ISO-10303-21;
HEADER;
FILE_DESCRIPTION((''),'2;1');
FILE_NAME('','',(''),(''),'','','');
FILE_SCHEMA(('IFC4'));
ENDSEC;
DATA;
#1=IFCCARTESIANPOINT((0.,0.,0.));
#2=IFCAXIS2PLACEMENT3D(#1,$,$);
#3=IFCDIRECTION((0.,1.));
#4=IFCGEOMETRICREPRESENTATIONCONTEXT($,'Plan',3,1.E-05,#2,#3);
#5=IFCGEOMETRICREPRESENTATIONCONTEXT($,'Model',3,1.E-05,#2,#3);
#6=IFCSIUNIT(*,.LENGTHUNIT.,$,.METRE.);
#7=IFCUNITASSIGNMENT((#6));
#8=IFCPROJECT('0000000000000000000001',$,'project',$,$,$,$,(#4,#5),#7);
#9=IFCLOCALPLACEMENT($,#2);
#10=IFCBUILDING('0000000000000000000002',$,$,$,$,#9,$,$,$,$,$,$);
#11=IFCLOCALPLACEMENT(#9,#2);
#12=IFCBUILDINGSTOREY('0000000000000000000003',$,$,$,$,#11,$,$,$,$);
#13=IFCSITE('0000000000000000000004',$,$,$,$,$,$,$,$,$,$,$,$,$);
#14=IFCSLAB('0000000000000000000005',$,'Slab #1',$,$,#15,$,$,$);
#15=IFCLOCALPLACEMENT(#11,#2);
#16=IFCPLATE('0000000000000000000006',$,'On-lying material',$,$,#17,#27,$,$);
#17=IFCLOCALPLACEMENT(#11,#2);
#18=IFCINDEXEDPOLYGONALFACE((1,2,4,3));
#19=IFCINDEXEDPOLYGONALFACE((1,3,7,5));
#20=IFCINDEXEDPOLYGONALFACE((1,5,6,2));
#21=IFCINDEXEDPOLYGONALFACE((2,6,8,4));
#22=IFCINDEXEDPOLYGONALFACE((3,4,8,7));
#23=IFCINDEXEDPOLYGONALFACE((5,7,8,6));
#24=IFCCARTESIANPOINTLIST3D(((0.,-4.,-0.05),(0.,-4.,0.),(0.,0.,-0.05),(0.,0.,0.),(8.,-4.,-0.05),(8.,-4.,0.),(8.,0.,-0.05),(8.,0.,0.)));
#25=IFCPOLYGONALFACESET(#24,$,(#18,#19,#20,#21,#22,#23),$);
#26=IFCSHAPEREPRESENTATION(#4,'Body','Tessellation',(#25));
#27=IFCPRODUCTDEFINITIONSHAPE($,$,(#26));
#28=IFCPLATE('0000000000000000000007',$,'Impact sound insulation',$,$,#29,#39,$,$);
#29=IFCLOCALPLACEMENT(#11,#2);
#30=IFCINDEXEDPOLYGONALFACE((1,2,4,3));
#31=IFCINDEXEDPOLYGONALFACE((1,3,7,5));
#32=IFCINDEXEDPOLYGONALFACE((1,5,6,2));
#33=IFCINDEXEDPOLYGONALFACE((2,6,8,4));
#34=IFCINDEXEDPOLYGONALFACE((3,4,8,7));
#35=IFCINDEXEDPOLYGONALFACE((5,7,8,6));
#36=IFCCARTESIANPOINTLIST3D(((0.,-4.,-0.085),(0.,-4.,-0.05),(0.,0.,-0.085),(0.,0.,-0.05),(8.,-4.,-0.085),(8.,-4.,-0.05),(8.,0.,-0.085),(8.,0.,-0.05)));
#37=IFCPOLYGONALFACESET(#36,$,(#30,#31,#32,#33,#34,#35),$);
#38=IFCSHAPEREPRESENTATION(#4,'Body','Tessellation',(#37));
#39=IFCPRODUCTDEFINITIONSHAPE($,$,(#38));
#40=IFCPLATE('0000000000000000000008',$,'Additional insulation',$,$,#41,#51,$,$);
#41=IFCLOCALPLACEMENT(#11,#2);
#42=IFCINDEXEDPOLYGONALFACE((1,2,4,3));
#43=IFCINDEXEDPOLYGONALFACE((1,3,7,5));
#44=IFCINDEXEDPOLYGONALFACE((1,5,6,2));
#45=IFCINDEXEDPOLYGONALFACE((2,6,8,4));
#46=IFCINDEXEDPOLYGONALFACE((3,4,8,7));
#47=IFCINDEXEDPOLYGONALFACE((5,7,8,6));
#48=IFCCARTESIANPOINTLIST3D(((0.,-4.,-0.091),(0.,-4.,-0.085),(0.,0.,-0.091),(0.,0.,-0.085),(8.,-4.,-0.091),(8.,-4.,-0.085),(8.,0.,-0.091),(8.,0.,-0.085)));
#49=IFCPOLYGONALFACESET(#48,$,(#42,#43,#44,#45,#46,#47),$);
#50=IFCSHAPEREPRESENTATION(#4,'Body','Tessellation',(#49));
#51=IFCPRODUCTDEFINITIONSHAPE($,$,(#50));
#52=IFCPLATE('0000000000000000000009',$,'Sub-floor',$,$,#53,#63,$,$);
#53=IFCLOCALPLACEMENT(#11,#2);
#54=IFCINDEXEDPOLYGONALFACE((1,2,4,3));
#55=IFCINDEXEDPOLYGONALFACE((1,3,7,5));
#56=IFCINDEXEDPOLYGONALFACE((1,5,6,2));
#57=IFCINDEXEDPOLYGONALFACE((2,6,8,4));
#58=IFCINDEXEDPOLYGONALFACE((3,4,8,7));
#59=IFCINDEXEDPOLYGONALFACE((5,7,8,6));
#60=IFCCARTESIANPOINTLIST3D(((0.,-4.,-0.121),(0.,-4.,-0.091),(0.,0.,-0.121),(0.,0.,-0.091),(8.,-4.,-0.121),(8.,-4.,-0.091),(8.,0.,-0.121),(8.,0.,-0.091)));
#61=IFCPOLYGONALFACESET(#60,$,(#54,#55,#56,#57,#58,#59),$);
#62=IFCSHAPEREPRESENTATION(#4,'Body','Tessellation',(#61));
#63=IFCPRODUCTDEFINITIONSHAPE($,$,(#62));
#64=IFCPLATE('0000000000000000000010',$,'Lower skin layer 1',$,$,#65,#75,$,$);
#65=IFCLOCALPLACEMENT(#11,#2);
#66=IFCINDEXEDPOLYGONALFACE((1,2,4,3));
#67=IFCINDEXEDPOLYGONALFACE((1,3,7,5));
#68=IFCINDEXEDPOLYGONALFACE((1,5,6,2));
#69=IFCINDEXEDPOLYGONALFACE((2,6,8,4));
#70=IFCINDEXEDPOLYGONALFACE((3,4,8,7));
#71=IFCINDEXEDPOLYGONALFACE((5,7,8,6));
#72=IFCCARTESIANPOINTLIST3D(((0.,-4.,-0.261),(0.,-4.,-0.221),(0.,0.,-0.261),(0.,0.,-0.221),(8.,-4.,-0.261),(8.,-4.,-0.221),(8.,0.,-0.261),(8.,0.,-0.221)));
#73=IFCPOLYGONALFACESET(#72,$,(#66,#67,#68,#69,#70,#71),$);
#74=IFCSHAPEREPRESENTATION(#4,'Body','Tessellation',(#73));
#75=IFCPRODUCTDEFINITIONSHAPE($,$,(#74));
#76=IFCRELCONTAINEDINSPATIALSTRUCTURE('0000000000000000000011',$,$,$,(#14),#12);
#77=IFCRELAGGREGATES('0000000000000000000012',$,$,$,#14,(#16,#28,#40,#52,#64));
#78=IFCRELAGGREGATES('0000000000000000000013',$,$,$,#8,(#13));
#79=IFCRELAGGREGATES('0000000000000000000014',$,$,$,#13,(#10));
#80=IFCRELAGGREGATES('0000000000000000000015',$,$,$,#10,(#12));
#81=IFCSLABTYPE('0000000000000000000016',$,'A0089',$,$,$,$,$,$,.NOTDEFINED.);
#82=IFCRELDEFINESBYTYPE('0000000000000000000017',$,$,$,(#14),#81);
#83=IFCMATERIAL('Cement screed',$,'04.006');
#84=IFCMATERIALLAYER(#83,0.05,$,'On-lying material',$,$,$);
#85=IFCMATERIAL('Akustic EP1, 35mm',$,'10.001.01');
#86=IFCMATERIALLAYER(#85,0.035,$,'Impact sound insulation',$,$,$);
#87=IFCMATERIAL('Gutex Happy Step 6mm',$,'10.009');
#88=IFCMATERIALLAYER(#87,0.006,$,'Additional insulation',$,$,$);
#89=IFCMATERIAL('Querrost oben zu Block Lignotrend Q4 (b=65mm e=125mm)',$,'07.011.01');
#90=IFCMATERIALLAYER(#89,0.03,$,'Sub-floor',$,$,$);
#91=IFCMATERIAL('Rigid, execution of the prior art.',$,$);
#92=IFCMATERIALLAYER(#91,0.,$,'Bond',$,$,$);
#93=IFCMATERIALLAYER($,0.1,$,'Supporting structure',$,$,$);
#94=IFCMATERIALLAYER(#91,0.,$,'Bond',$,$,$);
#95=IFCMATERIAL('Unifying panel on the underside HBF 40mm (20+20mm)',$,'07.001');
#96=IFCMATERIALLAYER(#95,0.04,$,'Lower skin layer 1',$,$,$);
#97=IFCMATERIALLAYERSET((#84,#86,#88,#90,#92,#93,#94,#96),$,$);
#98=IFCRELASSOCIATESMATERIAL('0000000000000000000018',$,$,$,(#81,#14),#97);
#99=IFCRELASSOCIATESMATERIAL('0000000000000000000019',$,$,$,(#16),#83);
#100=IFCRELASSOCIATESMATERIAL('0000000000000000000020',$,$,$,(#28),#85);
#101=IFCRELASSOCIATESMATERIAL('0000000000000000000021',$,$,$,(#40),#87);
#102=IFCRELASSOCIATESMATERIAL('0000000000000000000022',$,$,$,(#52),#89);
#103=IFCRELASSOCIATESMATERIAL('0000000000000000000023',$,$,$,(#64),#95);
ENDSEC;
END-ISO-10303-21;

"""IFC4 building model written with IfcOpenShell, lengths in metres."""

from ifc_helpers import new_model, si_unit, direction, frame, frame_2d, origin, origin_with_axes, place, context, project, spatial, rectangle, extrude, material, layer, layer_set, type_object, element, aggregate, save


model = new_model("IFC4")

# Units and contexts
plan_context = context("Plan", 3, precision=1e-05, world=origin(), true_north=direction((0.0, 1.0)))
model_context = context("Model", 3, precision=1e-05, world=origin(), true_north=direction((0.0, 1.0)))
ifc_project = project(units=[si_unit("LENGTHUNIT", "METRE")], contexts=[plan_context, model_context])

# Site, building, storey
site = spatial("IfcSite", under=ifc_project)
building_placement = place(None, origin())
building = spatial("IfcBuilding", under=site, at=building_placement)
storey_placement = place(building_placement, origin())
storey = spatial("IfcBuildingStorey", under=building, at=storey_placement)

# Slab, plates
ifc_material_1 = material(Name="Cement screed", Category="04.006")
ifc_layer_1 = layer(ifc_material_1, 0.05, Name="On-lying material")
ifc_material_2 = material(Name="Akustic EP1, 35mm", Category="10.001.01")
ifc_layer_2 = layer(ifc_material_2, 0.035, Name="Impact sound insulation")
ifc_material_3 = material(Name="Gutex Happy Step 6mm", Category="10.009")
ifc_layer_3 = layer(ifc_material_3, 0.006, Name="Additional insulation")
ifc_material_4 = material(Name="Querrost oben zu Block Lignotrend Q4 (b=65mm e=125mm)", Category="07.011.01")
ifc_layer_4 = layer(ifc_material_4, 0.03, Name="Sub-floor")
ifc_material_5 = material(Name="Rigid, execution of the prior art.")
ifc_layer_5 = layer(ifc_material_5, 0.0, Name="Bond")
ifc_layer_6 = layer(None, 0.1, Name="Supporting structure")
ifc_layer_7 = layer(ifc_material_5, 0.0, Name="Bond")
ifc_material_6 = material(Name="Unifying panel on the underside HBF 40mm (20+20mm)", Category="07.001")
ifc_layer_8 = layer(ifc_material_6, 0.04, Name="Lower skin layer 1")
ifc_layer_set = layer_set([ifc_layer_1, ifc_layer_2, ifc_layer_3, ifc_layer_4, ifc_layer_5, ifc_layer_6, ifc_layer_7, ifc_layer_8])
slab_type = type_object("IfcSlabType", Name="A0089", PredefinedType="NOTDEFINED", material=ifc_layer_set)
slab_placement = place(None, frame((0.0, 0.0, 0.0), z_axis=(0.0, 0.0, -1.0), x_axis=(1.0, 0.0, 0.0)))
slab = element("IfcSlab", 1, at=slab_placement, inside=storey, type_object=slab_type, material=ifc_layer_set, Name="Slab #1")
plate_1_placement = place(slab_placement, origin())
plate_1 = element("IfcPlate", 2, at=plate_1_placement, material=ifc_material_1, Name="On-lying material", context=plan_context, shape_type="SweptSolid", body=[
    extrude(rectangle(XDim=8.0, YDim=4.0, at=frame_2d((4.0, 2.0), x_axis=(1.0, 0.0))), origin_with_axes(), (0.0, 0.0, 1.0), 0.05),
])
plate_2_placement = place(slab_placement, origin())
plate_2 = element("IfcPlate", 3, at=plate_2_placement, material=ifc_material_2, Name="Impact sound insulation", context=plan_context, shape_type="SweptSolid", body=[
    extrude(rectangle(XDim=8.0, YDim=4.0, at=frame_2d((4.0, 2.0), x_axis=(1.0, 0.0))), frame((0.0, 0.0, 0.05), z_axis=(0.0, 0.0, 1.0), x_axis=(1.0, 0.0, 0.0)), (0.0, 0.0, 1.0), 0.035),
])
plate_3_placement = place(slab_placement, origin())
plate_3 = element("IfcPlate", 4, at=plate_3_placement, material=ifc_material_3, Name="Additional insulation", context=plan_context, shape_type="SweptSolid", body=[
    extrude(rectangle(XDim=8.0, YDim=4.0, at=frame_2d((4.0, 2.0), x_axis=(1.0, 0.0))), frame((0.0, 0.0, 0.085), z_axis=(0.0, 0.0, 1.0), x_axis=(1.0, 0.0, 0.0)), (0.0, 0.0, 1.0), 0.006),
])
plate_4_placement = place(slab_placement, origin())
plate_4 = element("IfcPlate", 5, at=plate_4_placement, material=ifc_material_4, Name="Sub-floor", context=plan_context, shape_type="SweptSolid", body=[
    extrude(rectangle(XDim=8.0, YDim=4.0, at=frame_2d((4.0, 2.0), x_axis=(1.0, 0.0))), frame((0.0, 0.0, 0.091), z_axis=(0.0, 0.0, 1.0), x_axis=(1.0, 0.0, 0.0)), (0.0, 0.0, 1.0), 0.03),
])
plate_5_placement = place(slab_placement, origin())
plate_5 = element("IfcPlate", 6, at=plate_5_placement, material=ifc_material_6, Name="Lower skin layer 1", context=plan_context, shape_type="SweptSolid", body=[
    extrude(rectangle(XDim=8.0, YDim=4.0, at=frame_2d((4.0, 2.0), x_axis=(1.0, 0.0))), frame((0.0, 0.0, 0.221), z_axis=(0.0, 0.0, 1.0), x_axis=(1.0, 0.0, 0.0)), (0.0, 0.0, 1.0), 0.04),
])
aggregate(slab, [plate_1, plate_2, plate_3, plate_4, plate_5])

save(model, "model.ifc")
